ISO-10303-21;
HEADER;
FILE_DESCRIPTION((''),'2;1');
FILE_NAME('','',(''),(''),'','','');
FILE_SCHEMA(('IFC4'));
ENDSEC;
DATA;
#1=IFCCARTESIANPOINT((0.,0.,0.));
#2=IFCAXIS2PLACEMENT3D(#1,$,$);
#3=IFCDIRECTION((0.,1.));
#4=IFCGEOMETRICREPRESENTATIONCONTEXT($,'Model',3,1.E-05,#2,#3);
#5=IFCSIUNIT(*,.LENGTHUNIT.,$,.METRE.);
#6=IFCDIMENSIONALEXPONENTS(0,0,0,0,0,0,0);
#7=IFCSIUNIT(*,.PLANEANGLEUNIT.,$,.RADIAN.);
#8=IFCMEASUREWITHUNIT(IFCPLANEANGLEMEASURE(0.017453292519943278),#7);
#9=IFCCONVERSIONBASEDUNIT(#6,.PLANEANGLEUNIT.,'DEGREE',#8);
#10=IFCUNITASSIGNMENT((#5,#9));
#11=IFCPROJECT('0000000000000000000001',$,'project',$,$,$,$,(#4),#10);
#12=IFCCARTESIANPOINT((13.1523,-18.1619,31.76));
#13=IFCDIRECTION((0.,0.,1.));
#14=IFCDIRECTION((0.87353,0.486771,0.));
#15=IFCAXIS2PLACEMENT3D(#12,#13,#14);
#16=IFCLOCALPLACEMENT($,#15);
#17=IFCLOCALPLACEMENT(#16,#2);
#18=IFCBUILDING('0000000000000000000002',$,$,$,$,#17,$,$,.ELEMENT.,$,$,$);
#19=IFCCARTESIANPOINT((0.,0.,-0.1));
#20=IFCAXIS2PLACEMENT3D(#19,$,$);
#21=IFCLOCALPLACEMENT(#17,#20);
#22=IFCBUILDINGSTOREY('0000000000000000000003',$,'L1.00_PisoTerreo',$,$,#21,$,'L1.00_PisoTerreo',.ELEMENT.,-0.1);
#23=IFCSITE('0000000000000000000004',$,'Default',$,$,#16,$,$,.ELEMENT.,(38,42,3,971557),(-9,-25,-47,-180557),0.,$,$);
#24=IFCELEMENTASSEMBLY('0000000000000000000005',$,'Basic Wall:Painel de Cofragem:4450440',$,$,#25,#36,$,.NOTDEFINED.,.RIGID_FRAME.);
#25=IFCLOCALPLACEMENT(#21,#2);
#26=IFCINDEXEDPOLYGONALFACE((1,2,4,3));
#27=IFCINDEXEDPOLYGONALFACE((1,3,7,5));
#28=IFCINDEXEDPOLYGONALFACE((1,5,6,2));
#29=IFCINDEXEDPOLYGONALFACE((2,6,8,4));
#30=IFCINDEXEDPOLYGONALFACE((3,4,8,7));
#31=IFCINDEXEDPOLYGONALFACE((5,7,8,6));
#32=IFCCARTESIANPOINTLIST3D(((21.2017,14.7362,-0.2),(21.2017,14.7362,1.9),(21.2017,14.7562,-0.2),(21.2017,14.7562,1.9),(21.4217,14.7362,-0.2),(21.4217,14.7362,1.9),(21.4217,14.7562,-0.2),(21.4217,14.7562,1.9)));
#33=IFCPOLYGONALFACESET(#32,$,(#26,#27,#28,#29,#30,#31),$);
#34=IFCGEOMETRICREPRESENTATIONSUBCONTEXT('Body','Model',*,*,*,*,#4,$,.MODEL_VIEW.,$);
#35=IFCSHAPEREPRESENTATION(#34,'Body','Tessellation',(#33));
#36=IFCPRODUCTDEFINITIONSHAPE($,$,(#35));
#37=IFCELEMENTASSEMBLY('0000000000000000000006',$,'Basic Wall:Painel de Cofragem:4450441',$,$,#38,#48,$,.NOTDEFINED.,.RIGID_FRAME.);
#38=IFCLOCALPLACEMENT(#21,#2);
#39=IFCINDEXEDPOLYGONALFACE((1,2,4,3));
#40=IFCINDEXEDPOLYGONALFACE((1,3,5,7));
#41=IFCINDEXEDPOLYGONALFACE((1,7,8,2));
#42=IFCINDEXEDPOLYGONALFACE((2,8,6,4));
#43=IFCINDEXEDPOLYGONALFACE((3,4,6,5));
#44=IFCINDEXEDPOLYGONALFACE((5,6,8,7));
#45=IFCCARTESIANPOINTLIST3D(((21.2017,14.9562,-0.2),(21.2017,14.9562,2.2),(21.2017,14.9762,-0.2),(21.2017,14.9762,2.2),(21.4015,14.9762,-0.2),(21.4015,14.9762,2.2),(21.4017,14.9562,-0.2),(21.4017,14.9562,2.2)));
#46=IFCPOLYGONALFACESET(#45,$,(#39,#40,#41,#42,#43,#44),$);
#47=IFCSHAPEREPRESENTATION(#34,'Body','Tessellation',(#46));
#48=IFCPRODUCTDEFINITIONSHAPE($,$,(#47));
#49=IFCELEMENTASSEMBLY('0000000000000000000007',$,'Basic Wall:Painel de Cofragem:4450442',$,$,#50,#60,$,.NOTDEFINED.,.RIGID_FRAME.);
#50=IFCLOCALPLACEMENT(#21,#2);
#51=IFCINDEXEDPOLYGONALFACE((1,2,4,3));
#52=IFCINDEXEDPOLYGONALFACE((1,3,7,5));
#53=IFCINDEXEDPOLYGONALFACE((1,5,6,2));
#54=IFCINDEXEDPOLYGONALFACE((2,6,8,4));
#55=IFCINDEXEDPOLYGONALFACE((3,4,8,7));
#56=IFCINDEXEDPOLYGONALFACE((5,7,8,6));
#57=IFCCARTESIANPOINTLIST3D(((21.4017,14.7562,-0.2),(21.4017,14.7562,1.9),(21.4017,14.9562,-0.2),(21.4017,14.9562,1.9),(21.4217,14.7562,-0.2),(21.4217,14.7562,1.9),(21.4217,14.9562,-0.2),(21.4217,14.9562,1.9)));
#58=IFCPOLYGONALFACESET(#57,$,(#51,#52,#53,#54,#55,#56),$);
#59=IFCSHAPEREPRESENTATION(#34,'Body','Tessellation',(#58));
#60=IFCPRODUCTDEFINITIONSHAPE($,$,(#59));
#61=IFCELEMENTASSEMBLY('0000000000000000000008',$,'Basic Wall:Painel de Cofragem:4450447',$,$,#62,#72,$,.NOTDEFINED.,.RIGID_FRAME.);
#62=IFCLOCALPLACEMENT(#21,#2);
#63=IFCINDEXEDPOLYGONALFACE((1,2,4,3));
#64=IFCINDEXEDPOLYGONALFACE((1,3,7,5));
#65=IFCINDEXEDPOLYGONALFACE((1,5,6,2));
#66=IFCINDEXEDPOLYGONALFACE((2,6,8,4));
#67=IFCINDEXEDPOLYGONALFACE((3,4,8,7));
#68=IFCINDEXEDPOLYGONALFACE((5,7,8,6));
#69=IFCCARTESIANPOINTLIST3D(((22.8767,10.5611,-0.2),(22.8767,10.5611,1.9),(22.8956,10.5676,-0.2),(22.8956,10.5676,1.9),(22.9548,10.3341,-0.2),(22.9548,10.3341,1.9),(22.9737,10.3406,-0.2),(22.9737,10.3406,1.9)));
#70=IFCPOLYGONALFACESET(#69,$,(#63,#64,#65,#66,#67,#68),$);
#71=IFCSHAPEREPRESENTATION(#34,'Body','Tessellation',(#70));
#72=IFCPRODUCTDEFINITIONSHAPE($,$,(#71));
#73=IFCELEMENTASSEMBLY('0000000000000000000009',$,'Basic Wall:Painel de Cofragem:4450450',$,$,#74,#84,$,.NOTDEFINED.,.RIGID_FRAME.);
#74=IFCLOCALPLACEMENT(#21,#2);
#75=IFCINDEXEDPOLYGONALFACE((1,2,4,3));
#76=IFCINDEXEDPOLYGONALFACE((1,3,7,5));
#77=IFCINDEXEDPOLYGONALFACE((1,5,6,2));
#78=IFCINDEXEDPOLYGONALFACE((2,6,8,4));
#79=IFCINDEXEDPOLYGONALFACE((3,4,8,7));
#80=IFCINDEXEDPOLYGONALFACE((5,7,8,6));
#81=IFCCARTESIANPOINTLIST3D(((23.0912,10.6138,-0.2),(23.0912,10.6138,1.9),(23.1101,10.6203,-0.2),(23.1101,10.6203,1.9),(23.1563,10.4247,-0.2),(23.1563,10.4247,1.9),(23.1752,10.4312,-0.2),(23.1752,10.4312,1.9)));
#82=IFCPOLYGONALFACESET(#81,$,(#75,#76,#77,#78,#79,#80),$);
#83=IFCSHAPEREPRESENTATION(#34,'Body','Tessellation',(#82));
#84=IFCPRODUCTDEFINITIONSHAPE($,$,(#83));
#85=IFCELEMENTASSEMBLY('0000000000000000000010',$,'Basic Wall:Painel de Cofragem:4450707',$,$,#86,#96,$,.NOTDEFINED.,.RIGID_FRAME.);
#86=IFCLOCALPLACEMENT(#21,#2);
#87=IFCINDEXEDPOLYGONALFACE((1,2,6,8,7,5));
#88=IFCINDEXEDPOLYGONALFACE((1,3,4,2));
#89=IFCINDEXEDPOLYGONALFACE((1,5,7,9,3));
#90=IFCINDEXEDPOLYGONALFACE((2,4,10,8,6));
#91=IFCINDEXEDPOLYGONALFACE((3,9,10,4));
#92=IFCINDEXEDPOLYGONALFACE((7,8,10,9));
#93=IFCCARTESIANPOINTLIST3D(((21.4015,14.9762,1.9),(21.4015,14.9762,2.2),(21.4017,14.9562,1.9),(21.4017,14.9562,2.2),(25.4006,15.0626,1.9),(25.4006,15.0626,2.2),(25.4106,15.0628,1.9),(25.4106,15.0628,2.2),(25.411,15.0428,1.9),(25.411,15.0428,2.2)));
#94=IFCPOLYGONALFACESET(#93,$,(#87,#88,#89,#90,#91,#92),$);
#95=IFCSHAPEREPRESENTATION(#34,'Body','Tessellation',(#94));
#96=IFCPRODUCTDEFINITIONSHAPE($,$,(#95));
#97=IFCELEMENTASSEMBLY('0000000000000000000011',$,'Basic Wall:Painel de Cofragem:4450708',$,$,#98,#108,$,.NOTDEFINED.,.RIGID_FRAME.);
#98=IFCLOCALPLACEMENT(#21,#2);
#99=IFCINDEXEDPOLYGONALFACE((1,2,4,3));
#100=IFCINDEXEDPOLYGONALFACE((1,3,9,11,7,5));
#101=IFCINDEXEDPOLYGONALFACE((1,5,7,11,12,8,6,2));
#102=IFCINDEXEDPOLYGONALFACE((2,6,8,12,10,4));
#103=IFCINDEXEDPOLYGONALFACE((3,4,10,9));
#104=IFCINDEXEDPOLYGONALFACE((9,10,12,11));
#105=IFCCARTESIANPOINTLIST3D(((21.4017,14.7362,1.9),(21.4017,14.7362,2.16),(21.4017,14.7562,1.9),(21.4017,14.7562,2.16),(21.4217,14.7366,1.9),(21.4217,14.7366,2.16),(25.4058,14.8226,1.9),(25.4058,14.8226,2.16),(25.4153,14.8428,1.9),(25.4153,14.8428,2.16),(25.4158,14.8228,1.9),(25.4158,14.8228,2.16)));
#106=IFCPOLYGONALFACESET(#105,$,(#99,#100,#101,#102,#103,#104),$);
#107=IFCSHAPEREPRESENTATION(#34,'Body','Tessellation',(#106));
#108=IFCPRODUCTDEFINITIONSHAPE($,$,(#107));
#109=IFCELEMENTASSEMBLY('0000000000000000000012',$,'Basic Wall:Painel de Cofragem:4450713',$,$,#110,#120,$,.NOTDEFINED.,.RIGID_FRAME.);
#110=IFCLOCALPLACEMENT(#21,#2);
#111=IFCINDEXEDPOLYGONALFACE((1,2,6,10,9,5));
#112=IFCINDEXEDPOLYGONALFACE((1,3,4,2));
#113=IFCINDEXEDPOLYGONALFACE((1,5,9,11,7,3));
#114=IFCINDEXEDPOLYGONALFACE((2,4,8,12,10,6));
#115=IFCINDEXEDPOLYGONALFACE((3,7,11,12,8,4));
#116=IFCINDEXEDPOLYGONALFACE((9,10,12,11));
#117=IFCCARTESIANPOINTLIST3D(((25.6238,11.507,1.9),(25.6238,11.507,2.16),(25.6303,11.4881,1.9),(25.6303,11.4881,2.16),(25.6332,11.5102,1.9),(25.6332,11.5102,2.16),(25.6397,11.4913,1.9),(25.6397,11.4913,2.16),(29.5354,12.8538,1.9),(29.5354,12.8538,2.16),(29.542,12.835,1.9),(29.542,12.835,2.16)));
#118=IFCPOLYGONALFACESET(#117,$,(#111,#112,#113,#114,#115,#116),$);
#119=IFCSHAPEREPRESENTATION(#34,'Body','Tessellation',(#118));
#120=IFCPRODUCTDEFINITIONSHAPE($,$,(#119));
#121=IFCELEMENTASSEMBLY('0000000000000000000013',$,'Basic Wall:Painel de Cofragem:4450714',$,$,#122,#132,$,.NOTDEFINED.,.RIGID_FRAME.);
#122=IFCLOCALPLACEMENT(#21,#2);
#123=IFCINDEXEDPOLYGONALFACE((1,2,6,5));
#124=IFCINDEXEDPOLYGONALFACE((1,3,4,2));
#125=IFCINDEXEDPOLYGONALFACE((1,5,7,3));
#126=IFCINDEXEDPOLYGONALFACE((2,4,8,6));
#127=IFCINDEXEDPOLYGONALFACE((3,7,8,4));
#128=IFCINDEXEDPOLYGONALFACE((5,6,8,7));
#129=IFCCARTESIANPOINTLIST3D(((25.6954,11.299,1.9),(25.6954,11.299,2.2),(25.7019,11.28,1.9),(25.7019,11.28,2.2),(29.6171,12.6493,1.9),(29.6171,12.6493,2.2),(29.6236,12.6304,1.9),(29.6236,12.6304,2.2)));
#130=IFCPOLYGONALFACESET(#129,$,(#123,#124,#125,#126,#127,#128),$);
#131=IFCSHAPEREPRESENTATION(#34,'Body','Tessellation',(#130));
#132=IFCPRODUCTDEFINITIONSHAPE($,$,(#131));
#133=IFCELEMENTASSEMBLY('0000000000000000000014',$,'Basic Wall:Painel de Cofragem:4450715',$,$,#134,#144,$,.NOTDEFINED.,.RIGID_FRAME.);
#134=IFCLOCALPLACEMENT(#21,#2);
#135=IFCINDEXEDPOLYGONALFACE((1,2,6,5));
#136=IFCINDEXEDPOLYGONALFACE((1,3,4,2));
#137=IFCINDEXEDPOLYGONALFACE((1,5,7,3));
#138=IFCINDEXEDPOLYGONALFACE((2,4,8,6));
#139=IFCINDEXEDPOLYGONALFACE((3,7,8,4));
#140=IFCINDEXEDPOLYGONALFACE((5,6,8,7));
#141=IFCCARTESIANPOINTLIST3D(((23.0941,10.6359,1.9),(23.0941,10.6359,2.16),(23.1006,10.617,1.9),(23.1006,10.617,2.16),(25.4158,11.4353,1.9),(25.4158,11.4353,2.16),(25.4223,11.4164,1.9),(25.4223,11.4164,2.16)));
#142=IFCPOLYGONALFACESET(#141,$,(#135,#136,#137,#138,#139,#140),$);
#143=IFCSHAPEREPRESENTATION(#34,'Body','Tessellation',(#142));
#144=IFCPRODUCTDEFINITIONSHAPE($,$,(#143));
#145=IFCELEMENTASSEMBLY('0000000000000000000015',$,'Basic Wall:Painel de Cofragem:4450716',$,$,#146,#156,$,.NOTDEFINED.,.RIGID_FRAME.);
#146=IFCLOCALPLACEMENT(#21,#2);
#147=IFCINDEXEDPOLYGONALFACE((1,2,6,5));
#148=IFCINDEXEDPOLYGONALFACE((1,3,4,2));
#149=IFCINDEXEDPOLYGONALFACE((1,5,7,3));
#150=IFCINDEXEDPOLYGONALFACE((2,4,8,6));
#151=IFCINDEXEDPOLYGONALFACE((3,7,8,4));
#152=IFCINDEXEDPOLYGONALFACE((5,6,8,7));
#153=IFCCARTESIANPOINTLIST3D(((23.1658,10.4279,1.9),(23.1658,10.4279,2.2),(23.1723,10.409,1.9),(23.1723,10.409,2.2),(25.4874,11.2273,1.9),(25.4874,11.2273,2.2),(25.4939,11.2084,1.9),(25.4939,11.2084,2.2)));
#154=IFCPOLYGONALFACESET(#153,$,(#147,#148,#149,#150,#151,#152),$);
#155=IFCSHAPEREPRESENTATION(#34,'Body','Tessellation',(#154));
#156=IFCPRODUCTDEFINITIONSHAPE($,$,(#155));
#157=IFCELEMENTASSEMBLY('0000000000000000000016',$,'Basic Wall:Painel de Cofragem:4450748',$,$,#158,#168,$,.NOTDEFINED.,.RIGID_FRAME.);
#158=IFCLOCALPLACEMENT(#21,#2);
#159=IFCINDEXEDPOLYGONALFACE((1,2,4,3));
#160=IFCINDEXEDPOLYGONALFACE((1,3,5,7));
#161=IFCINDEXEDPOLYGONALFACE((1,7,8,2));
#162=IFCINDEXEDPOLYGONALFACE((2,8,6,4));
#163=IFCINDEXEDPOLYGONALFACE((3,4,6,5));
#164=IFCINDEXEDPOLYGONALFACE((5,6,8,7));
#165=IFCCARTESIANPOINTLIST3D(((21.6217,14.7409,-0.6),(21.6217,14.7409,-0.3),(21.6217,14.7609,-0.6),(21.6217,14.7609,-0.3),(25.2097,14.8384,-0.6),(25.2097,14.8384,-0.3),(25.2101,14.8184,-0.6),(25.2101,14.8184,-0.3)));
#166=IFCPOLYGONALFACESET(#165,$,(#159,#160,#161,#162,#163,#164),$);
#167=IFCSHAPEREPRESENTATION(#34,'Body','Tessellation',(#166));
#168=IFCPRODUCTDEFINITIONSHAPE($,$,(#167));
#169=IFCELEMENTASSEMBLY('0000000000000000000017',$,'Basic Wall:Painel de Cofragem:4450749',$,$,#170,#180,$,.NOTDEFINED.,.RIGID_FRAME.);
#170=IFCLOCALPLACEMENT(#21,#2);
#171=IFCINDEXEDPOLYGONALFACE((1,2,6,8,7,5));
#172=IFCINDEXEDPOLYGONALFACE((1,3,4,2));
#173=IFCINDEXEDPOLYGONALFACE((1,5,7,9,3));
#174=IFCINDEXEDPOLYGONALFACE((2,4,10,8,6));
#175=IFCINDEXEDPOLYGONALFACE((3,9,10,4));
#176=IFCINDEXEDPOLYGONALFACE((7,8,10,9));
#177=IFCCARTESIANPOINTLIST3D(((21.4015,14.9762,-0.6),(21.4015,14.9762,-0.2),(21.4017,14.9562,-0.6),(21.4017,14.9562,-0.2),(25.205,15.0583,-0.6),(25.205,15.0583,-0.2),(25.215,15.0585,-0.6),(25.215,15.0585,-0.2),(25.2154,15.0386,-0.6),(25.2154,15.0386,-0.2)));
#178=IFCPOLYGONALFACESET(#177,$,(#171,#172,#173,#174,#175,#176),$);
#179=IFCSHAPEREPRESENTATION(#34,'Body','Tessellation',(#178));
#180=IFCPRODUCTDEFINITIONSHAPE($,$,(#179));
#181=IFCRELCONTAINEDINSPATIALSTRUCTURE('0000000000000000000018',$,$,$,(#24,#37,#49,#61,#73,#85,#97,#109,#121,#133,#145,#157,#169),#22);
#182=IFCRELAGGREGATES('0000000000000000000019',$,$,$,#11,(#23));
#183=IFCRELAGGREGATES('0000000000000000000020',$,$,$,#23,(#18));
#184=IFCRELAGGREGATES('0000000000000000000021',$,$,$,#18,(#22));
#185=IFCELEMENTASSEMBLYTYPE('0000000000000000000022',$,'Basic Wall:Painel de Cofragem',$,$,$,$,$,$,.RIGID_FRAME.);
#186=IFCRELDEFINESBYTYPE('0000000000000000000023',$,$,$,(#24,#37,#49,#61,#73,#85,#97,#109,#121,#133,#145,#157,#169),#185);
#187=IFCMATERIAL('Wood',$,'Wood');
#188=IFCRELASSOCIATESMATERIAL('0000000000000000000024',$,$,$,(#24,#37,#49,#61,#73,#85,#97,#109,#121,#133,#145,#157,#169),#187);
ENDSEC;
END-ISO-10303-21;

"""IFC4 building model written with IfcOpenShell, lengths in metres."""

from ifc_helpers import new_model, entity, si_unit, converted_unit, direction, frame, origin, place, context, subcontext, project, spatial, indexed_curve, outline, extrude, material, type_object, element, save


model = new_model("IFC4")

# Units and contexts
model_context = context("Model", 3, precision=1e-05, world=origin(), true_north=direction((0.0, 1.0)))
body_context = subcontext(model_context, "Body", "Model", "MODEL_VIEW")
ifc_project = project(units=[si_unit("LENGTHUNIT", "METRE"), converted_unit("PLANEANGLEUNIT", "DEGREE", entity("IfcPlaneAngleMeasure", 0.017453292519943278), si_unit("PLANEANGLEUNIT", "RADIAN"), dimensions=[0, 0, 0, 0, 0, 0, 0])], contexts=[model_context])

# Site, building, storey
site_placement = place(None, frame((13.1523, -18.1619, 31.76), z_axis=(0.0, 0.0, 1.0), x_axis=(0.87353, 0.486771, 0.0)))
site = spatial("IfcSite", under=ifc_project, at=site_placement, Name="Default", CompositionType="ELEMENT", RefLatitude=(38, 42, 3, 971557), RefLongitude=(-9, -25, -47, -180557), RefElevation=0.0)
building_placement = place(site_placement, origin())
building = spatial("IfcBuilding", under=site, at=building_placement, CompositionType="ELEMENT")
storey_placement = place(building_placement, frame((0.0, 0.0, -0.1)))
storey = spatial("IfcBuildingStorey", under=building, at=storey_placement, Name="L1.00_PisoTerreo", LongName="L1.00_PisoTerreo", CompositionType="ELEMENT", Elevation=-0.1)

# Element assemblies
ifc_material_1 = material(Name="Wood", Category="Wood")
element_assembly_type = type_object("IfcElementAssemblyType", Name="Basic Wall:Painel de Cofragem", PredefinedType="RIGID_FRAME")
assembly_1_placement = place(storey_placement, frame((21.4217, 14.7462, -0.2), z_axis=(0.0, 0.0, 1.0), x_axis=(-1.0, 0.0, 0.0)))
element("IfcElementAssembly", 1, at=assembly_1_placement, inside=storey, type_object=element_assembly_type, material=ifc_material_1, Name="Basic Wall:Painel de Cofragem:4450440", AssemblyPlace="NOTDEFINED", PredefinedType="RIGID_FRAME", context=body_context, shape_type="SweptSolid", body=[
    extrude(outline(indexed_curve([(0.22, 0.01), (0.0, 0.01), (0.0, -0.01), (0.22, -0.01), (0.22, 0.01)], self_intersect=False)), origin(), (0.0, 0.0, 1.0), 2.1),
])
assembly_2_placement = place(storey_placement, frame((21.4017, 14.9662, -0.2), z_axis=(0.0, 0.0, 1.0), x_axis=(-1.0, 0.0, 0.0)))
element("IfcElementAssembly", 2, at=assembly_2_placement, inside=storey, type_object=element_assembly_type, material=ifc_material_1, Name="Basic Wall:Painel de Cofragem:4450441", AssemblyPlace="NOTDEFINED", PredefinedType="RIGID_FRAME", context=body_context, shape_type="SweptSolid", body=[
    extrude(outline(indexed_curve([(0.2, -0.01), (0.2, 0.01), (0.0, 0.01), (0.0002, -0.01), (0.2, -0.01)], self_intersect=False)), origin(), (0.0, 0.0, 1.0), 2.4),
])
assembly_3_placement = place(storey_placement, frame((21.4117, 14.9562, -0.2), z_axis=(0.0, 0.0, 1.0), x_axis=(0.0, -1.0, 0.0)))
element("IfcElementAssembly", 3, at=assembly_3_placement, inside=storey, type_object=element_assembly_type, material=ifc_material_1, Name="Basic Wall:Painel de Cofragem:4450442", AssemblyPlace="NOTDEFINED", PredefinedType="RIGID_FRAME", context=body_context, shape_type="SweptSolid", body=[
    extrude(outline(indexed_curve([(0.2, 0.01), (0.0, 0.01), (0.0, -0.01), (0.2, -0.01), (0.2, 0.01)], self_intersect=False)), origin(), (0.0, 0.0, 1.0), 2.1),
])
assembly_4_placement = place(storey_placement, frame((22.8861, 10.5643, -0.2), z_axis=(0.0, 0.0, 1.0), x_axis=(0.325568, -0.945519, 0.0)))
element("IfcElementAssembly", 4, at=assembly_4_placement, inside=storey, type_object=element_assembly_type, material=ifc_material_1, Name="Basic Wall:Painel de Cofragem:4450447", AssemblyPlace="NOTDEFINED", PredefinedType="RIGID_FRAME", context=body_context, shape_type="SweptSolid", body=[
    extrude(outline(indexed_curve([(0.24, 0.01), (0.0, 0.01), (0.0, -0.01), (0.24, -0.01), (0.24, 0.01)], self_intersect=False)), origin(), (0.0, 0.0, 1.0), 2.1),
])
assembly_5_placement = place(storey_placement, frame((23.1006, 10.617, -0.2), z_axis=(0.0, 0.0, 1.0), x_axis=(0.325568, -0.945519, 0.0)))
element("IfcElementAssembly", 5, at=assembly_5_placement, inside=storey, type_object=element_assembly_type, material=ifc_material_1, Name="Basic Wall:Painel de Cofragem:4450450", AssemblyPlace="NOTDEFINED", PredefinedType="RIGID_FRAME", context=body_context, shape_type="SweptSolid", body=[
    extrude(outline(indexed_curve([(0.2, 0.01), (0.0, 0.01), (0.0, -0.01), (0.2, -0.01), (0.2, 0.01)], self_intersect=False)), origin(), (0.0, 0.0, 1.0), 2.1),
])
assembly_6_placement = place(storey_placement, frame((21.4015, 14.9662, 1.9), z_axis=(0.0, 0.0, 1.0), x_axis=(0.999767, 0.021581, 0.0)))
element("IfcElementAssembly", 6, at=assembly_6_placement, inside=storey, type_object=element_assembly_type, material=ifc_material_1, Name="Basic Wall:Painel de Cofragem:4450707", AssemblyPlace="NOTDEFINED", PredefinedType="RIGID_FRAME", context=body_context, shape_type="SweptSolid", body=[
    extrude(outline(indexed_curve([(4.0103, -0.01), (4.0103, 0.01), (4.0003, 0.01), (0.0002, 0.01), (0.0, -0.01), (4.0103, -0.01)], self_intersect=False)), origin(), (0.0, 0.0, 1.0), 0.3),
])
assembly_7_placement = place(storey_placement, frame((21.4015, 14.7462, 1.9), z_axis=(0.0, 0.0, 1.0), x_axis=(0.999767, 0.021581, 0.0)))
element("IfcElementAssembly", 7, at=assembly_7_placement, inside=storey, type_object=element_assembly_type, material=ifc_material_1, Name="Basic Wall:Painel de Cofragem:4450708", AssemblyPlace="NOTDEFINED", PredefinedType="RIGID_FRAME", context=body_context, shape_type="SweptSolid", body=[
    extrude(outline(indexed_curve([(4.015, -0.01), (4.015, 0.01), (0.0004, 0.01), (0.0, -0.01), (0.02, -0.01), (4.005, -0.01), (4.015, -0.01)], self_intersect=False)), origin(), (0.0, 0.0, 1.0), 0.26),
])
assembly_8_placement = place(storey_placement, frame((25.627, 11.4975, 1.9), z_axis=(0.0, 0.0, 1.0), x_axis=(0.945519, 0.325568, 0.0)))
element("IfcElementAssembly", 8, at=assembly_8_placement, inside=storey, type_object=element_assembly_type, material=ifc_material_1, Name="Basic Wall:Painel de Cofragem:4450713", AssemblyPlace="NOTDEFINED", PredefinedType="RIGID_FRAME", context=body_context, shape_type="SweptSolid", body=[
    extrude(outline(indexed_curve([(4.1371, -0.01), (4.137, 0.01), (0.01, 0.01), (0.0, 0.01), (0.0, -0.01), (0.01, -0.01), (4.1371, -0.01)], self_intersect=False)), origin(), (0.0, 0.0, 1.0), 0.26),
])
assembly_9_placement = place(storey_placement, frame((25.6987, 11.2895, 1.9), z_axis=(0.0, 0.0, 1.0), x_axis=(0.945519, 0.325568, 0.0)))
element("IfcElementAssembly", 9, at=assembly_9_placement, inside=storey, type_object=element_assembly_type, material=ifc_material_1, Name="Basic Wall:Painel de Cofragem:4450714", AssemblyPlace="NOTDEFINED", PredefinedType="RIGID_FRAME", context=body_context, shape_type="SweptSolid", body=[
    extrude(outline(indexed_curve([(4.1477, 0.01), (0.0, 0.01), (0.0, -0.01), (4.1477, -0.01), (4.1477, 0.01)], self_intersect=False)), origin(), (0.0, 0.0, 1.0), 0.3),
])
assembly_10_placement = place(storey_placement, frame((23.0974, 10.6265, 1.9), z_axis=(0.0, 0.0, 1.0), x_axis=(0.945519, 0.325568, 0.0)))
element("IfcElementAssembly", 10, at=assembly_10_placement, inside=storey, type_object=element_assembly_type, material=ifc_material_1, Name="Basic Wall:Painel de Cofragem:4450715", AssemblyPlace="NOTDEFINED", PredefinedType="RIGID_FRAME", context=body_context, shape_type="SweptSolid", body=[
    extrude(outline(indexed_curve([(2.4554, 0.01), (0.0, 0.01), (0.0, -0.01), (2.4554, -0.01), (2.4554, 0.01)], self_intersect=False)), origin(), (0.0, 0.0, 1.0), 0.26),
])
assembly_11_placement = place(storey_placement, frame((23.169, 10.4185, 1.9), z_axis=(0.0, 0.0, 1.0), x_axis=(0.945519, 0.325568, 0.0)))
element("IfcElementAssembly", 11, at=assembly_11_placement, inside=storey, type_object=element_assembly_type, material=ifc_material_1, Name="Basic Wall:Painel de Cofragem:4450716", AssemblyPlace="NOTDEFINED", PredefinedType="RIGID_FRAME", context=body_context, shape_type="SweptSolid", body=[
    extrude(outline(indexed_curve([(2.4554, 0.01), (0.0, 0.01), (0.0, -0.01), (2.4554, -0.01), (2.4554, 0.01)], self_intersect=False)), origin(), (0.0, 0.0, 1.0), 0.3),
])
assembly_12_placement = place(storey_placement, frame((21.6215, 14.7509, -0.6), z_axis=(0.0, 0.0, 1.0), x_axis=(0.999767, 0.021581, 0.0)))
element("IfcElementAssembly", 12, at=assembly_12_placement, inside=storey, type_object=element_assembly_type, material=ifc_material_1, Name="Basic Wall:Painel de Cofragem:4450748", AssemblyPlace="NOTDEFINED", PredefinedType="RIGID_FRAME", context=body_context, shape_type="SweptSolid", body=[
    extrude(outline(indexed_curve([(3.5893, -0.01), (3.5893, 0.01), (0.0004, 0.01), (0.0, -0.01), (3.5893, -0.01)], self_intersect=False)), origin(), (0.0, 0.0, 1.0), 0.3),
])
assembly_13_placement = place(storey_placement, frame((21.4015, 14.9662, -0.6), z_axis=(0.0, 0.0, 1.0), x_axis=(0.999767, 0.021581, 0.0)))
element("IfcElementAssembly", 13, at=assembly_13_placement, inside=storey, type_object=element_assembly_type, material=ifc_material_1, Name="Basic Wall:Painel de Cofragem:4450749", AssemblyPlace="NOTDEFINED", PredefinedType="RIGID_FRAME", context=body_context, shape_type="SweptSolid", body=[
    extrude(outline(indexed_curve([(3.8146, -0.01), (3.8146, 0.01), (3.8046, 0.01), (0.0002, 0.01), (0.0, -0.01), (3.8146, -0.01)], self_intersect=False)), origin(), (0.0, 0.0, 1.0), 0.4),
])

save(model, "model.ifc")
